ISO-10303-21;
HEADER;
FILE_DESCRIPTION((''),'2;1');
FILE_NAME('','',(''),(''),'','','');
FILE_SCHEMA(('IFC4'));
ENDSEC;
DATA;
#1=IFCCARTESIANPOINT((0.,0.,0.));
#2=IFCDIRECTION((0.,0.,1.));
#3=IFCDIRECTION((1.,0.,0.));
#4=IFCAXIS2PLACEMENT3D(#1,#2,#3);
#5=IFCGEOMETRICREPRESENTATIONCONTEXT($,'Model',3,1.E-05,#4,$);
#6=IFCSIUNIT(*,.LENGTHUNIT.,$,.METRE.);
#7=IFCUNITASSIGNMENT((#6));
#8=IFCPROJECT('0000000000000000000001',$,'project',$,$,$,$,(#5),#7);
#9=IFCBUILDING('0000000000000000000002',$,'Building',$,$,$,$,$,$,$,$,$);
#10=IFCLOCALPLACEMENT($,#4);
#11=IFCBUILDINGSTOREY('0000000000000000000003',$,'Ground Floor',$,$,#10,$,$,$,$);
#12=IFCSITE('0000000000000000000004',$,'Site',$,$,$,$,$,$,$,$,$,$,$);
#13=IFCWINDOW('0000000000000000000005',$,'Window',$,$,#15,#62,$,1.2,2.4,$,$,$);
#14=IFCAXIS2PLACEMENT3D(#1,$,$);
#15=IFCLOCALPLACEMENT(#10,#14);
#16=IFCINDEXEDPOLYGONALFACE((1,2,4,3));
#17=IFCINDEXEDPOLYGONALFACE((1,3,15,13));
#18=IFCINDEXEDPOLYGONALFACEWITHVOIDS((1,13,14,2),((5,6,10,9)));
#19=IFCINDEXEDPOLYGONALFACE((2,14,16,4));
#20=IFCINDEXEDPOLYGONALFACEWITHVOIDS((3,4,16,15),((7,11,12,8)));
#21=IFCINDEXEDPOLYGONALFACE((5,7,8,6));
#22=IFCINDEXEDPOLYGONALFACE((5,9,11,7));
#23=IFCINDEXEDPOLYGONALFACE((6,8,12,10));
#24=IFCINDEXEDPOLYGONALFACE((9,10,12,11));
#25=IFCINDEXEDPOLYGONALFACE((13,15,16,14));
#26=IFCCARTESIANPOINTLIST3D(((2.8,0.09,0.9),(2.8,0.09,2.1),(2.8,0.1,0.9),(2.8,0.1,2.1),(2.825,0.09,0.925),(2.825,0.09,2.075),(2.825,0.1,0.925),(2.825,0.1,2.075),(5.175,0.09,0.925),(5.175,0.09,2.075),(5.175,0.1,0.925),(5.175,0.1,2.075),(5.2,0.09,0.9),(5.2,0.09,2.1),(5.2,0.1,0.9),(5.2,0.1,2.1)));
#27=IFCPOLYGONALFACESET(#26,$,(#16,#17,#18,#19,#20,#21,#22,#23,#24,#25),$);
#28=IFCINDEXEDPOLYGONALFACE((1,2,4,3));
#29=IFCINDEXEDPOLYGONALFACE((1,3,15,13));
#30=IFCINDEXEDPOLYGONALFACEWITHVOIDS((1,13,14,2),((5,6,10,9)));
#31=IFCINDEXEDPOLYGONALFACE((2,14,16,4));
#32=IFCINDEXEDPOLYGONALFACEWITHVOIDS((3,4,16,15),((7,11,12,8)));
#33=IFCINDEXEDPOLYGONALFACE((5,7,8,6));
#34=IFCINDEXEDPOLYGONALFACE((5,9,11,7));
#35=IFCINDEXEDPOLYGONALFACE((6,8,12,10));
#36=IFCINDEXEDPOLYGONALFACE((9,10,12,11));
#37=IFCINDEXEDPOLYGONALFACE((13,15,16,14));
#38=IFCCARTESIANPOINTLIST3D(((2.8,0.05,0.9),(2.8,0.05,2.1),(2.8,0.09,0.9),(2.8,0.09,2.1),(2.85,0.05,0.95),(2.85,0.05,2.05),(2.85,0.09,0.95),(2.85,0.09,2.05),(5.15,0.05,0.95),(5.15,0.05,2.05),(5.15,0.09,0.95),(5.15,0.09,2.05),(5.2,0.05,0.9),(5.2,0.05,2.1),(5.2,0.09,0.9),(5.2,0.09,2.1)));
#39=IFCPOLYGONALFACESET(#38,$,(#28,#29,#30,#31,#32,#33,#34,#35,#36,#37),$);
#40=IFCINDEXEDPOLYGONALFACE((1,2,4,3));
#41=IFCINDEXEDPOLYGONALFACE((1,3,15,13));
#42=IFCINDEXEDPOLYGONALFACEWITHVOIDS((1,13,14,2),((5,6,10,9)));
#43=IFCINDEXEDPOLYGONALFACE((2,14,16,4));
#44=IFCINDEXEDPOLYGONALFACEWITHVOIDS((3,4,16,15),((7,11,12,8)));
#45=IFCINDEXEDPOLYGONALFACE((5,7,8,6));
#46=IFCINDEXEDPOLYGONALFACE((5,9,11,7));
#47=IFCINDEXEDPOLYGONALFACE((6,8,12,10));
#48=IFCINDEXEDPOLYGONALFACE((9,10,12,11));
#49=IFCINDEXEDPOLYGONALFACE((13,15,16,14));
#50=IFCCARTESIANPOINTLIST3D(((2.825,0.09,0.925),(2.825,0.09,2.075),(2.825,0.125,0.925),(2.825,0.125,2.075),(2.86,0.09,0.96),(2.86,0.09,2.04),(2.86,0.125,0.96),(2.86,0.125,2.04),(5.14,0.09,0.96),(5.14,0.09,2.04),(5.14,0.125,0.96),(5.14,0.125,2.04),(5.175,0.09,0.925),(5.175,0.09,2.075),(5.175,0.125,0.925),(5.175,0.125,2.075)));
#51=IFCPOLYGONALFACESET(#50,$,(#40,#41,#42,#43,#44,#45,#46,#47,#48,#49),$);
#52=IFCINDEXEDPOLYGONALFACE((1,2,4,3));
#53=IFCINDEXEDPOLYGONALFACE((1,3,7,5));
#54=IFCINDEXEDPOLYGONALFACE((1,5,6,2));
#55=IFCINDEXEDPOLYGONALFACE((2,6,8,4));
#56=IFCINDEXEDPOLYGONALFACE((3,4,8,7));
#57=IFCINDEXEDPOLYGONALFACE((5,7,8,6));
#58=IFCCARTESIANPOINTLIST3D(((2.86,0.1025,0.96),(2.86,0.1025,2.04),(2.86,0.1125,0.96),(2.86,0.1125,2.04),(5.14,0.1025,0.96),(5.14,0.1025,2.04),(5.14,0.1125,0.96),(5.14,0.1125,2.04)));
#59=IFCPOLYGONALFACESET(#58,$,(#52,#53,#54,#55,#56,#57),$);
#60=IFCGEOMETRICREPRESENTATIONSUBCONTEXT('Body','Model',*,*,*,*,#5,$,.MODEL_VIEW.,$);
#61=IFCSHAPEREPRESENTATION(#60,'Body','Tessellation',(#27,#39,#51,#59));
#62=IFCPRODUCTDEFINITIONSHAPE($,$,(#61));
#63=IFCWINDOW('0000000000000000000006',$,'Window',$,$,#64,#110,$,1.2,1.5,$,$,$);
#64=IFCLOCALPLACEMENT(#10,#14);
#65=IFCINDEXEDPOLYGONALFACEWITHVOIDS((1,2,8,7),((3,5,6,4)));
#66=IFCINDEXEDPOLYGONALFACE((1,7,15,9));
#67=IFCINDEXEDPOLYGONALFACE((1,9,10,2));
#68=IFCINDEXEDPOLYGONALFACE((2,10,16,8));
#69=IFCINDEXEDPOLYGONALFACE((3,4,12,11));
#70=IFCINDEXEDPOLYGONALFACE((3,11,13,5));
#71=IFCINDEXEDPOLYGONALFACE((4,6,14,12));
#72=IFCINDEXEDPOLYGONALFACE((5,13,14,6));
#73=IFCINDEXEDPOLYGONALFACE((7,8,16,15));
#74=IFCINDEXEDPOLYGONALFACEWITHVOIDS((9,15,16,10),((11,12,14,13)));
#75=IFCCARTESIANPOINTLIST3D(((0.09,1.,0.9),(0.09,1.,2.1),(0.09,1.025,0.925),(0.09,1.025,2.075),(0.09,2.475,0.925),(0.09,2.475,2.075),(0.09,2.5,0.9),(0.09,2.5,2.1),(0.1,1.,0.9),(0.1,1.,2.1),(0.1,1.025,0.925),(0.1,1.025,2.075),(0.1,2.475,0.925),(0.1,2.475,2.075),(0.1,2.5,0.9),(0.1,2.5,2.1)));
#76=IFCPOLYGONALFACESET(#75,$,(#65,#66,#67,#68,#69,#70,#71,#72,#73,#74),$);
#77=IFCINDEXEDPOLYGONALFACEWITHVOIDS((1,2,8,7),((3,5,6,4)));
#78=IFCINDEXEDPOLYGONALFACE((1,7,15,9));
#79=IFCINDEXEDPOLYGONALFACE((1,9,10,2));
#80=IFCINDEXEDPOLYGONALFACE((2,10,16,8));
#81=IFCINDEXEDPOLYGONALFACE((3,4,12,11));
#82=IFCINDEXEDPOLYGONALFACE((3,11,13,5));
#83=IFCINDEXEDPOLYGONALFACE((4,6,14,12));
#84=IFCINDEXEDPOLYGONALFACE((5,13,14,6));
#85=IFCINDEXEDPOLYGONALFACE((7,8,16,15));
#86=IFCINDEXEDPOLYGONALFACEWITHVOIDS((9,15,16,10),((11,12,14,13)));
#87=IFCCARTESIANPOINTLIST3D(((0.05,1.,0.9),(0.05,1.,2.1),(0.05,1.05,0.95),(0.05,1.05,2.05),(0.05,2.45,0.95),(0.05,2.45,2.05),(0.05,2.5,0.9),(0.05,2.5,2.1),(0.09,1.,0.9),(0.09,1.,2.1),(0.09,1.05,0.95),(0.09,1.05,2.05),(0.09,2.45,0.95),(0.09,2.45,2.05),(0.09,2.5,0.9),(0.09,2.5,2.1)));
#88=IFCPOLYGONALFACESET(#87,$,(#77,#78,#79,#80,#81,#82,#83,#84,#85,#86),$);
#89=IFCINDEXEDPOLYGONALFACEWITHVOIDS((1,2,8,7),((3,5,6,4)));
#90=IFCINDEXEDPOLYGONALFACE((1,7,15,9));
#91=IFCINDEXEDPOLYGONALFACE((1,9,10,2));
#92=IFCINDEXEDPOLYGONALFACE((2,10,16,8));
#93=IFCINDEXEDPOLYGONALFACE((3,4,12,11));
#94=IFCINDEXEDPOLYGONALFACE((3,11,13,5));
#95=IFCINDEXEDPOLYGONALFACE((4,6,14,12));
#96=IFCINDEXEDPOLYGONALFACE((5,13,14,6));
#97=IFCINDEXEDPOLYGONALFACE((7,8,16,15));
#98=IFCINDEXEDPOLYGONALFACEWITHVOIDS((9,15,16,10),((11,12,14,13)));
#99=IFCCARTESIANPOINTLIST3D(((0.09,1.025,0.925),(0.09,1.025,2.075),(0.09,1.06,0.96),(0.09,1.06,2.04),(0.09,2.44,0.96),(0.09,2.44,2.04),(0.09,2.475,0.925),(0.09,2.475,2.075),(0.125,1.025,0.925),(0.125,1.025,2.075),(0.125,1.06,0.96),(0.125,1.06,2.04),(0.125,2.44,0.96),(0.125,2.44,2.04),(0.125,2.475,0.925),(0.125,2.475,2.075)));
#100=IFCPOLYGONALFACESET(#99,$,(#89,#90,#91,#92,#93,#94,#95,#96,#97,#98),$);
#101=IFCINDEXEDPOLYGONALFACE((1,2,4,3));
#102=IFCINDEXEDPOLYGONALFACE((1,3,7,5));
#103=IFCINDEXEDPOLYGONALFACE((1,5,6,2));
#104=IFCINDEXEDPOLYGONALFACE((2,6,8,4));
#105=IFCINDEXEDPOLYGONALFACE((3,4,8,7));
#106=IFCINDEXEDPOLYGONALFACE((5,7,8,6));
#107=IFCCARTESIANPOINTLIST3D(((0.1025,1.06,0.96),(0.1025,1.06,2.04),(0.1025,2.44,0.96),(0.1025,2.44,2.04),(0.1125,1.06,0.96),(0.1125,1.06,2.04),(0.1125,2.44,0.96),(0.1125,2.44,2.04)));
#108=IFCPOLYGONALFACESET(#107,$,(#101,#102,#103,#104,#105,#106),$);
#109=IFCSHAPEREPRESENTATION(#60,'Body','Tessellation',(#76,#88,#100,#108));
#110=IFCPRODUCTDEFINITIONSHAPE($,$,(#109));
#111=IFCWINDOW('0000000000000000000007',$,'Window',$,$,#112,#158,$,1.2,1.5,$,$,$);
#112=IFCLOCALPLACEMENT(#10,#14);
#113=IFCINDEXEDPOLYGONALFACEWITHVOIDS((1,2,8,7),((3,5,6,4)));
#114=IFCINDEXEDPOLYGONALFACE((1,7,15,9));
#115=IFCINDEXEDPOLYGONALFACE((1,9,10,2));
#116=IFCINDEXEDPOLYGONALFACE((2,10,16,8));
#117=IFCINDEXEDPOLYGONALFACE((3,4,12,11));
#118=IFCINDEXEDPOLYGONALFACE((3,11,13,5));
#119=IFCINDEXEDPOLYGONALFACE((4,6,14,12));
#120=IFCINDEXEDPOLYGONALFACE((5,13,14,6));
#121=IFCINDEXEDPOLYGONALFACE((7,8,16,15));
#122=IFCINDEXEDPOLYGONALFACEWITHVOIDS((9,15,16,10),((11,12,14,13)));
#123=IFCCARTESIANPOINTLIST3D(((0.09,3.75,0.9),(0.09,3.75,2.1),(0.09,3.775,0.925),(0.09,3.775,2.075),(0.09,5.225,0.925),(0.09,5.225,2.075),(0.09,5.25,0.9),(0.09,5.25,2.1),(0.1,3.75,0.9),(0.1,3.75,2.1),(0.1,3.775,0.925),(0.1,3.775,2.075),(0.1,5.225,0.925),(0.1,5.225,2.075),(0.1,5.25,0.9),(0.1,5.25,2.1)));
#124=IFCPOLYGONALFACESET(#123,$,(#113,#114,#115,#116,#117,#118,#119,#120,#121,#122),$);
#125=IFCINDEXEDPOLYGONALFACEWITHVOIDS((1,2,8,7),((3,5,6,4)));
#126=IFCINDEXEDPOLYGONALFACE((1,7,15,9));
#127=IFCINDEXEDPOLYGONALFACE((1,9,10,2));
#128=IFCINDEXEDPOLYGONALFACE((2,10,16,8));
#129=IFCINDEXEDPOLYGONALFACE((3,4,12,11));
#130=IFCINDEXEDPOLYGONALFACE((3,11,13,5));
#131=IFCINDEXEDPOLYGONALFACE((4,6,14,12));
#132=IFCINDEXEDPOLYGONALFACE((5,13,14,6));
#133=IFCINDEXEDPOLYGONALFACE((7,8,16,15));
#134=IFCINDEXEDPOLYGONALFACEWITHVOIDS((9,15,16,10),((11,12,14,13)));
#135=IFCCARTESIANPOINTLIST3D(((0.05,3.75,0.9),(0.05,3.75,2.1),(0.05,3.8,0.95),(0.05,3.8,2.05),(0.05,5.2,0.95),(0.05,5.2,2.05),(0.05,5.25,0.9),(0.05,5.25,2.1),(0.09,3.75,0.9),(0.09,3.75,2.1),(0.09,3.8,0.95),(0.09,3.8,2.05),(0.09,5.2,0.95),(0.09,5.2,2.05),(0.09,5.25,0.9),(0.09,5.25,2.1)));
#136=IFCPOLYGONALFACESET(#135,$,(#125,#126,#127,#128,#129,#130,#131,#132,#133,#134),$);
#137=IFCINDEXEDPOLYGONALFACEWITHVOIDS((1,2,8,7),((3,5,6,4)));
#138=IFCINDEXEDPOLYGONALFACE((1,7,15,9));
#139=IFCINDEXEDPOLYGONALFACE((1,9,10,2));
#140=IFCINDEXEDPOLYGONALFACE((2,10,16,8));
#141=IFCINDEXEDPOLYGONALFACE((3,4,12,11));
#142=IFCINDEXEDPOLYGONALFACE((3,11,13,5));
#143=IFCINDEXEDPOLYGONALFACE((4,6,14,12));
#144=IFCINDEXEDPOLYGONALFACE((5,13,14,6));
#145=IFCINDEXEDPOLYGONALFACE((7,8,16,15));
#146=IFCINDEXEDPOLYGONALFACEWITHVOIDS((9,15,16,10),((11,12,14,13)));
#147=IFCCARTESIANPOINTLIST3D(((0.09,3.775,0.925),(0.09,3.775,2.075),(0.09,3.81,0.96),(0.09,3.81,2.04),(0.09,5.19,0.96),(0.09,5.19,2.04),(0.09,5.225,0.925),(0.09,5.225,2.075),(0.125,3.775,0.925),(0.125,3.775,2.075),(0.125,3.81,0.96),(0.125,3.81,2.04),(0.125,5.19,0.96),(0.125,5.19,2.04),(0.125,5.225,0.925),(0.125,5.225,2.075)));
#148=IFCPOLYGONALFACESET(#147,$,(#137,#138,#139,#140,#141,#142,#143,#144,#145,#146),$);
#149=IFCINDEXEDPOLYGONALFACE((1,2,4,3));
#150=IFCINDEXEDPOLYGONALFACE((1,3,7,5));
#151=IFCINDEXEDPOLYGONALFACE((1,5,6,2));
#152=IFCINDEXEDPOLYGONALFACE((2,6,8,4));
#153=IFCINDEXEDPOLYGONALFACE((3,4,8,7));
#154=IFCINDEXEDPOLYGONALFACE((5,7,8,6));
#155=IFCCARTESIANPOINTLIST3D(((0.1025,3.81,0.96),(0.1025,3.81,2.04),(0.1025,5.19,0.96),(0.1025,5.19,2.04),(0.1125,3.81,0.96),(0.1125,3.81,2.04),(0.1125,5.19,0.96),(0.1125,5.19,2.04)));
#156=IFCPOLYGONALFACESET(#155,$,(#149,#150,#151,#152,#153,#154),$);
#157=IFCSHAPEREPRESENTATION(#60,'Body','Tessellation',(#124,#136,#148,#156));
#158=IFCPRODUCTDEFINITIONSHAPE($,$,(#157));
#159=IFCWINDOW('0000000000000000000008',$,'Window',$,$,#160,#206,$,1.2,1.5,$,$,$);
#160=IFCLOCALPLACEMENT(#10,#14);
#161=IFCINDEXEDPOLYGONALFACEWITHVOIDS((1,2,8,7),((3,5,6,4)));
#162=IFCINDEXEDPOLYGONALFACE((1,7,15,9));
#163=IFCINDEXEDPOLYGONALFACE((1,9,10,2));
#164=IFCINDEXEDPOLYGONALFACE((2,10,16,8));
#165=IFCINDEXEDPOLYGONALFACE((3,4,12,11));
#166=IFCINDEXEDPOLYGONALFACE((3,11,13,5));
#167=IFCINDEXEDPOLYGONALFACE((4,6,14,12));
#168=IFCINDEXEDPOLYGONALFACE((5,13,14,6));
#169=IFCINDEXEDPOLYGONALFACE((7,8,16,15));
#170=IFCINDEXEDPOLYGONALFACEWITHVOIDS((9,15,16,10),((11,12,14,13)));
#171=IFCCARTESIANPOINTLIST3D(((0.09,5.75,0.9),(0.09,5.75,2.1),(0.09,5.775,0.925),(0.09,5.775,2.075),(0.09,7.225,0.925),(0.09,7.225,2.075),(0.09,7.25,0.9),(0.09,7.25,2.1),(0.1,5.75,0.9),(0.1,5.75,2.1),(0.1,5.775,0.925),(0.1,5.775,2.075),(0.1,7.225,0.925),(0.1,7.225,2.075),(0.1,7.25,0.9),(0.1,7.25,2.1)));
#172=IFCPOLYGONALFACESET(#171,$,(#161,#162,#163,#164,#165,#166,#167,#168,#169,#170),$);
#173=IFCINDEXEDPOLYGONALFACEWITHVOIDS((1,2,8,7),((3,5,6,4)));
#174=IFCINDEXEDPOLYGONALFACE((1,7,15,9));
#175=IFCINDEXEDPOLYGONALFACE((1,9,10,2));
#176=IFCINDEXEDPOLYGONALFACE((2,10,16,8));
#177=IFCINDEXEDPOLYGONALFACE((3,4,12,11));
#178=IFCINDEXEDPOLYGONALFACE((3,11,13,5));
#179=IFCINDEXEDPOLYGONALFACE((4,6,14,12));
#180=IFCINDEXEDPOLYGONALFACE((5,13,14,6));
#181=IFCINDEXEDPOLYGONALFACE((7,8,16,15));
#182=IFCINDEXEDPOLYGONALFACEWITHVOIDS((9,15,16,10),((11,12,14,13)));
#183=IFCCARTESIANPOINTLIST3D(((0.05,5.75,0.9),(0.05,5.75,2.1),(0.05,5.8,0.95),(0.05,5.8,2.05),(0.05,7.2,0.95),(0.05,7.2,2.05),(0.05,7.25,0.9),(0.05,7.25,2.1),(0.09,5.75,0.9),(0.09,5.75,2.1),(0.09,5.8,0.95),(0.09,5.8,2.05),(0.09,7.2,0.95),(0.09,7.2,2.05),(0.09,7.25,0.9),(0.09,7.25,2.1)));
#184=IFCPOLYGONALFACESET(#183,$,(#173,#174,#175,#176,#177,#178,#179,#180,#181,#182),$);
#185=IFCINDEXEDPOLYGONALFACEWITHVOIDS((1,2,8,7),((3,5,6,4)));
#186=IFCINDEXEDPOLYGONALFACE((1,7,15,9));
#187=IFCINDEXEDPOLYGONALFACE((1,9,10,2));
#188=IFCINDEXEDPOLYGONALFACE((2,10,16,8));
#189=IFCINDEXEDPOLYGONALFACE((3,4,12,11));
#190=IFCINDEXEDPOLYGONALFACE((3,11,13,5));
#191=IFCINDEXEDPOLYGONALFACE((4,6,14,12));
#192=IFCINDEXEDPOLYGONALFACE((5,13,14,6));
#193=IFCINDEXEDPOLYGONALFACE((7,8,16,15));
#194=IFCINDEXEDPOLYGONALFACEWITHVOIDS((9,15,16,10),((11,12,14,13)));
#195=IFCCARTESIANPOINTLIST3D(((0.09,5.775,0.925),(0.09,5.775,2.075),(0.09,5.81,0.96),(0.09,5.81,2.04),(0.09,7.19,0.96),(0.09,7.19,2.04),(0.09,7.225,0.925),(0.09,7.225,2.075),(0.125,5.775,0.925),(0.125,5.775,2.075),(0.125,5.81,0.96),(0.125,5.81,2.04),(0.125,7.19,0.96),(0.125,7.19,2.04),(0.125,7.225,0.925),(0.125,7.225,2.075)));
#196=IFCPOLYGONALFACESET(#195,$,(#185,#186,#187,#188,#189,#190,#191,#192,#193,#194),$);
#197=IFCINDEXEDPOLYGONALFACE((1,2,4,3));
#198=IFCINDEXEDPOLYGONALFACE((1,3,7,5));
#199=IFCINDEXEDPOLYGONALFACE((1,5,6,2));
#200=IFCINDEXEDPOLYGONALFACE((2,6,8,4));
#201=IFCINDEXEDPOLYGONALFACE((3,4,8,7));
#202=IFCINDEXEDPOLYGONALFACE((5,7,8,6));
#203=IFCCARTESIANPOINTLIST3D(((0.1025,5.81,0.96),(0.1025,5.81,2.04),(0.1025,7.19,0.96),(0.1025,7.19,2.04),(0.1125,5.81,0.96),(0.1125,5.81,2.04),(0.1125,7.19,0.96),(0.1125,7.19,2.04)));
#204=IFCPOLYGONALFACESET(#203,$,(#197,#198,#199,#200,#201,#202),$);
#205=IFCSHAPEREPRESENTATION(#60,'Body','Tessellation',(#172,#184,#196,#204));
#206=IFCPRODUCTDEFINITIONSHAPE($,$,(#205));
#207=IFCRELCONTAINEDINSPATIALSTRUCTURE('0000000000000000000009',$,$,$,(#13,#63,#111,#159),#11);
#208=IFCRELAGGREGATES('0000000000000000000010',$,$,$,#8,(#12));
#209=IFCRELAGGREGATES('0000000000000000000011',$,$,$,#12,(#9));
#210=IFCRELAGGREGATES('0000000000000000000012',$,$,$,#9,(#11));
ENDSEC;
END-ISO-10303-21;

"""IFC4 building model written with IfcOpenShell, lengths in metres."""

from ifc_helpers import new_model, si_unit, frame, origin_with_axes, place, context, subcontext, project, spatial, line, indexed_curve, outline, extrude, element, save


model = new_model("IFC4")

# Units and contexts
model_context = context("Model", 3, precision=1e-05, world=origin_with_axes())
body_context = subcontext(model_context, "Body", "Model", "MODEL_VIEW")
ifc_project = project(units=[si_unit("LENGTHUNIT", "METRE")], contexts=[model_context])

# Site, building, storey
site = spatial("IfcSite", under=ifc_project, Name="Site")
building = spatial("IfcBuilding", under=site, Name="Building")
storey_placement = place(None, origin_with_axes())
storey = spatial("IfcBuildingStorey", under=building, at=storey_placement, Name="Ground Floor")

# Windows
window_placement = place(storey_placement, frame((2.8, 0.0, 0.9), z_axis=(0.0, 0.0, 1.0), x_axis=(1.0, 0.0, 0.0)))
element("IfcWindow", 1, at=window_placement, inside=storey, Name="Window", OverallHeight=1.2, OverallWidth=2.4, context=body_context, shape_type="SweptSolid", body=[
    extrude(outline(indexed_curve([(0.0, 0.0), (2.4, 0.0), (2.4, 1.2), (0.0, 1.2)], segments=[line(1, 2, 3, 4, 1)]), holes=[indexed_curve([(0.025, 0.025), (2.375, 0.025), (2.375, 1.175), (0.025, 1.175)], segments=[line(1, 2, 3, 4, 1)])]), frame((0.0, 0.09, 0.0), z_axis=(0.0, -1.0, 0.0), x_axis=(1.0, 0.0, 0.0)), (0.0, 0.0, -1.0), 0.01),
    extrude(outline(indexed_curve([(0.0, 0.0), (2.4, 0.0), (2.4, 1.2), (0.0, 1.2)], segments=[line(1, 2, 3, 4, 1)]), holes=[indexed_curve([(0.05, 0.05), (2.35, 0.05), (2.35, 1.15), (0.05, 1.15)], segments=[line(1, 2, 3, 4, 1)])]), frame((0.0, 0.05, 0.0), z_axis=(0.0, -1.0, 0.0), x_axis=(1.0, 0.0, 0.0)), (0.0, 0.0, -1.0), 0.04),
    extrude(outline(indexed_curve([(0.0, 0.0), (2.35, 0.0), (2.35, 1.15), (0.0, 1.15)], segments=[line(1, 2, 3, 4, 1)]), holes=[indexed_curve([(0.035, 0.035), (2.315, 0.035), (2.315, 1.115), (0.035, 1.115)], segments=[line(1, 2, 3, 4, 1)])]), frame((0.025, 0.09, 0.025), z_axis=(0.0, -1.0, 0.0), x_axis=(1.0, 0.0, 0.0)), (0.0, 0.0, -1.0), 0.035),
    extrude(outline(indexed_curve([(0.035, 0.035), (2.315, 0.035), (2.315, 1.115), (0.035, 1.115)], segments=[line(1, 2, 3, 4, 1)])), frame((0.025, 0.1025, 0.025), z_axis=(0.0, -1.0, 0.0), x_axis=(1.0, 0.0, 0.0)), (0.0, 0.0, -1.0), 0.01),
])
for number, where, z_axis, x_axis, name in (
    (2, (0.0, 2.5, 0.9), (0.0, 0.0, 1.0), (0.0, -1.0, 0.0), "Window"),
    (3, (0.0, 5.25, 0.9), (0.0, 0.0, 1.0), (0.0, -1.0, 0.0), "Window"),
    (4, (0.0, 7.25, 0.9), (0.0, 0.0, 1.0), (0.0, -1.0, 0.0), "Window"),
):
    element("IfcWindow", number, at=place(storey_placement, frame(where, z_axis=z_axis, x_axis=x_axis)), inside=storey, Name=name, OverallHeight=1.2, OverallWidth=1.5, context=body_context, shape_type="SweptSolid", body=[
        extrude(outline(indexed_curve([(0.0, 0.0), (1.5, 0.0), (1.5, 1.2), (0.0, 1.2)], segments=[line(1, 2, 3, 4, 1)]), holes=[indexed_curve([(0.025, 0.025), (1.475, 0.025), (1.475, 1.175), (0.025, 1.175)], segments=[line(1, 2, 3, 4, 1)])]), frame((0.0, 0.09, 0.0), z_axis=(0.0, -1.0, 0.0), x_axis=(1.0, 0.0, 0.0)), (0.0, 0.0, -1.0), 0.01),
        extrude(outline(indexed_curve([(0.0, 0.0), (1.5, 0.0), (1.5, 1.2), (0.0, 1.2)], segments=[line(1, 2, 3, 4, 1)]), holes=[indexed_curve([(0.05, 0.05), (1.45, 0.05), (1.45, 1.15), (0.05, 1.15)], segments=[line(1, 2, 3, 4, 1)])]), frame((0.0, 0.05, 0.0), z_axis=(0.0, -1.0, 0.0), x_axis=(1.0, 0.0, 0.0)), (0.0, 0.0, -1.0), 0.04),
        extrude(outline(indexed_curve([(0.0, 0.0), (1.45, 0.0), (1.45, 1.15), (0.0, 1.15)], segments=[line(1, 2, 3, 4, 1)]), holes=[indexed_curve([(0.035, 0.035), (1.415, 0.035), (1.415, 1.115), (0.035, 1.115)], segments=[line(1, 2, 3, 4, 1)])]), frame((0.025, 0.09, 0.025), z_axis=(0.0, -1.0, 0.0), x_axis=(1.0, 0.0, 0.0)), (0.0, 0.0, -1.0), 0.035),
        extrude(outline(indexed_curve([(0.035, 0.035), (1.415, 0.035), (1.415, 1.115), (0.035, 1.115)], segments=[line(1, 2, 3, 4, 1)])), frame((0.025, 0.1025, 0.025), z_axis=(0.0, -1.0, 0.0), x_axis=(1.0, 0.0, 0.0)), (0.0, 0.0, -1.0), 0.01),
    ])

save(model, "model.ifc")
